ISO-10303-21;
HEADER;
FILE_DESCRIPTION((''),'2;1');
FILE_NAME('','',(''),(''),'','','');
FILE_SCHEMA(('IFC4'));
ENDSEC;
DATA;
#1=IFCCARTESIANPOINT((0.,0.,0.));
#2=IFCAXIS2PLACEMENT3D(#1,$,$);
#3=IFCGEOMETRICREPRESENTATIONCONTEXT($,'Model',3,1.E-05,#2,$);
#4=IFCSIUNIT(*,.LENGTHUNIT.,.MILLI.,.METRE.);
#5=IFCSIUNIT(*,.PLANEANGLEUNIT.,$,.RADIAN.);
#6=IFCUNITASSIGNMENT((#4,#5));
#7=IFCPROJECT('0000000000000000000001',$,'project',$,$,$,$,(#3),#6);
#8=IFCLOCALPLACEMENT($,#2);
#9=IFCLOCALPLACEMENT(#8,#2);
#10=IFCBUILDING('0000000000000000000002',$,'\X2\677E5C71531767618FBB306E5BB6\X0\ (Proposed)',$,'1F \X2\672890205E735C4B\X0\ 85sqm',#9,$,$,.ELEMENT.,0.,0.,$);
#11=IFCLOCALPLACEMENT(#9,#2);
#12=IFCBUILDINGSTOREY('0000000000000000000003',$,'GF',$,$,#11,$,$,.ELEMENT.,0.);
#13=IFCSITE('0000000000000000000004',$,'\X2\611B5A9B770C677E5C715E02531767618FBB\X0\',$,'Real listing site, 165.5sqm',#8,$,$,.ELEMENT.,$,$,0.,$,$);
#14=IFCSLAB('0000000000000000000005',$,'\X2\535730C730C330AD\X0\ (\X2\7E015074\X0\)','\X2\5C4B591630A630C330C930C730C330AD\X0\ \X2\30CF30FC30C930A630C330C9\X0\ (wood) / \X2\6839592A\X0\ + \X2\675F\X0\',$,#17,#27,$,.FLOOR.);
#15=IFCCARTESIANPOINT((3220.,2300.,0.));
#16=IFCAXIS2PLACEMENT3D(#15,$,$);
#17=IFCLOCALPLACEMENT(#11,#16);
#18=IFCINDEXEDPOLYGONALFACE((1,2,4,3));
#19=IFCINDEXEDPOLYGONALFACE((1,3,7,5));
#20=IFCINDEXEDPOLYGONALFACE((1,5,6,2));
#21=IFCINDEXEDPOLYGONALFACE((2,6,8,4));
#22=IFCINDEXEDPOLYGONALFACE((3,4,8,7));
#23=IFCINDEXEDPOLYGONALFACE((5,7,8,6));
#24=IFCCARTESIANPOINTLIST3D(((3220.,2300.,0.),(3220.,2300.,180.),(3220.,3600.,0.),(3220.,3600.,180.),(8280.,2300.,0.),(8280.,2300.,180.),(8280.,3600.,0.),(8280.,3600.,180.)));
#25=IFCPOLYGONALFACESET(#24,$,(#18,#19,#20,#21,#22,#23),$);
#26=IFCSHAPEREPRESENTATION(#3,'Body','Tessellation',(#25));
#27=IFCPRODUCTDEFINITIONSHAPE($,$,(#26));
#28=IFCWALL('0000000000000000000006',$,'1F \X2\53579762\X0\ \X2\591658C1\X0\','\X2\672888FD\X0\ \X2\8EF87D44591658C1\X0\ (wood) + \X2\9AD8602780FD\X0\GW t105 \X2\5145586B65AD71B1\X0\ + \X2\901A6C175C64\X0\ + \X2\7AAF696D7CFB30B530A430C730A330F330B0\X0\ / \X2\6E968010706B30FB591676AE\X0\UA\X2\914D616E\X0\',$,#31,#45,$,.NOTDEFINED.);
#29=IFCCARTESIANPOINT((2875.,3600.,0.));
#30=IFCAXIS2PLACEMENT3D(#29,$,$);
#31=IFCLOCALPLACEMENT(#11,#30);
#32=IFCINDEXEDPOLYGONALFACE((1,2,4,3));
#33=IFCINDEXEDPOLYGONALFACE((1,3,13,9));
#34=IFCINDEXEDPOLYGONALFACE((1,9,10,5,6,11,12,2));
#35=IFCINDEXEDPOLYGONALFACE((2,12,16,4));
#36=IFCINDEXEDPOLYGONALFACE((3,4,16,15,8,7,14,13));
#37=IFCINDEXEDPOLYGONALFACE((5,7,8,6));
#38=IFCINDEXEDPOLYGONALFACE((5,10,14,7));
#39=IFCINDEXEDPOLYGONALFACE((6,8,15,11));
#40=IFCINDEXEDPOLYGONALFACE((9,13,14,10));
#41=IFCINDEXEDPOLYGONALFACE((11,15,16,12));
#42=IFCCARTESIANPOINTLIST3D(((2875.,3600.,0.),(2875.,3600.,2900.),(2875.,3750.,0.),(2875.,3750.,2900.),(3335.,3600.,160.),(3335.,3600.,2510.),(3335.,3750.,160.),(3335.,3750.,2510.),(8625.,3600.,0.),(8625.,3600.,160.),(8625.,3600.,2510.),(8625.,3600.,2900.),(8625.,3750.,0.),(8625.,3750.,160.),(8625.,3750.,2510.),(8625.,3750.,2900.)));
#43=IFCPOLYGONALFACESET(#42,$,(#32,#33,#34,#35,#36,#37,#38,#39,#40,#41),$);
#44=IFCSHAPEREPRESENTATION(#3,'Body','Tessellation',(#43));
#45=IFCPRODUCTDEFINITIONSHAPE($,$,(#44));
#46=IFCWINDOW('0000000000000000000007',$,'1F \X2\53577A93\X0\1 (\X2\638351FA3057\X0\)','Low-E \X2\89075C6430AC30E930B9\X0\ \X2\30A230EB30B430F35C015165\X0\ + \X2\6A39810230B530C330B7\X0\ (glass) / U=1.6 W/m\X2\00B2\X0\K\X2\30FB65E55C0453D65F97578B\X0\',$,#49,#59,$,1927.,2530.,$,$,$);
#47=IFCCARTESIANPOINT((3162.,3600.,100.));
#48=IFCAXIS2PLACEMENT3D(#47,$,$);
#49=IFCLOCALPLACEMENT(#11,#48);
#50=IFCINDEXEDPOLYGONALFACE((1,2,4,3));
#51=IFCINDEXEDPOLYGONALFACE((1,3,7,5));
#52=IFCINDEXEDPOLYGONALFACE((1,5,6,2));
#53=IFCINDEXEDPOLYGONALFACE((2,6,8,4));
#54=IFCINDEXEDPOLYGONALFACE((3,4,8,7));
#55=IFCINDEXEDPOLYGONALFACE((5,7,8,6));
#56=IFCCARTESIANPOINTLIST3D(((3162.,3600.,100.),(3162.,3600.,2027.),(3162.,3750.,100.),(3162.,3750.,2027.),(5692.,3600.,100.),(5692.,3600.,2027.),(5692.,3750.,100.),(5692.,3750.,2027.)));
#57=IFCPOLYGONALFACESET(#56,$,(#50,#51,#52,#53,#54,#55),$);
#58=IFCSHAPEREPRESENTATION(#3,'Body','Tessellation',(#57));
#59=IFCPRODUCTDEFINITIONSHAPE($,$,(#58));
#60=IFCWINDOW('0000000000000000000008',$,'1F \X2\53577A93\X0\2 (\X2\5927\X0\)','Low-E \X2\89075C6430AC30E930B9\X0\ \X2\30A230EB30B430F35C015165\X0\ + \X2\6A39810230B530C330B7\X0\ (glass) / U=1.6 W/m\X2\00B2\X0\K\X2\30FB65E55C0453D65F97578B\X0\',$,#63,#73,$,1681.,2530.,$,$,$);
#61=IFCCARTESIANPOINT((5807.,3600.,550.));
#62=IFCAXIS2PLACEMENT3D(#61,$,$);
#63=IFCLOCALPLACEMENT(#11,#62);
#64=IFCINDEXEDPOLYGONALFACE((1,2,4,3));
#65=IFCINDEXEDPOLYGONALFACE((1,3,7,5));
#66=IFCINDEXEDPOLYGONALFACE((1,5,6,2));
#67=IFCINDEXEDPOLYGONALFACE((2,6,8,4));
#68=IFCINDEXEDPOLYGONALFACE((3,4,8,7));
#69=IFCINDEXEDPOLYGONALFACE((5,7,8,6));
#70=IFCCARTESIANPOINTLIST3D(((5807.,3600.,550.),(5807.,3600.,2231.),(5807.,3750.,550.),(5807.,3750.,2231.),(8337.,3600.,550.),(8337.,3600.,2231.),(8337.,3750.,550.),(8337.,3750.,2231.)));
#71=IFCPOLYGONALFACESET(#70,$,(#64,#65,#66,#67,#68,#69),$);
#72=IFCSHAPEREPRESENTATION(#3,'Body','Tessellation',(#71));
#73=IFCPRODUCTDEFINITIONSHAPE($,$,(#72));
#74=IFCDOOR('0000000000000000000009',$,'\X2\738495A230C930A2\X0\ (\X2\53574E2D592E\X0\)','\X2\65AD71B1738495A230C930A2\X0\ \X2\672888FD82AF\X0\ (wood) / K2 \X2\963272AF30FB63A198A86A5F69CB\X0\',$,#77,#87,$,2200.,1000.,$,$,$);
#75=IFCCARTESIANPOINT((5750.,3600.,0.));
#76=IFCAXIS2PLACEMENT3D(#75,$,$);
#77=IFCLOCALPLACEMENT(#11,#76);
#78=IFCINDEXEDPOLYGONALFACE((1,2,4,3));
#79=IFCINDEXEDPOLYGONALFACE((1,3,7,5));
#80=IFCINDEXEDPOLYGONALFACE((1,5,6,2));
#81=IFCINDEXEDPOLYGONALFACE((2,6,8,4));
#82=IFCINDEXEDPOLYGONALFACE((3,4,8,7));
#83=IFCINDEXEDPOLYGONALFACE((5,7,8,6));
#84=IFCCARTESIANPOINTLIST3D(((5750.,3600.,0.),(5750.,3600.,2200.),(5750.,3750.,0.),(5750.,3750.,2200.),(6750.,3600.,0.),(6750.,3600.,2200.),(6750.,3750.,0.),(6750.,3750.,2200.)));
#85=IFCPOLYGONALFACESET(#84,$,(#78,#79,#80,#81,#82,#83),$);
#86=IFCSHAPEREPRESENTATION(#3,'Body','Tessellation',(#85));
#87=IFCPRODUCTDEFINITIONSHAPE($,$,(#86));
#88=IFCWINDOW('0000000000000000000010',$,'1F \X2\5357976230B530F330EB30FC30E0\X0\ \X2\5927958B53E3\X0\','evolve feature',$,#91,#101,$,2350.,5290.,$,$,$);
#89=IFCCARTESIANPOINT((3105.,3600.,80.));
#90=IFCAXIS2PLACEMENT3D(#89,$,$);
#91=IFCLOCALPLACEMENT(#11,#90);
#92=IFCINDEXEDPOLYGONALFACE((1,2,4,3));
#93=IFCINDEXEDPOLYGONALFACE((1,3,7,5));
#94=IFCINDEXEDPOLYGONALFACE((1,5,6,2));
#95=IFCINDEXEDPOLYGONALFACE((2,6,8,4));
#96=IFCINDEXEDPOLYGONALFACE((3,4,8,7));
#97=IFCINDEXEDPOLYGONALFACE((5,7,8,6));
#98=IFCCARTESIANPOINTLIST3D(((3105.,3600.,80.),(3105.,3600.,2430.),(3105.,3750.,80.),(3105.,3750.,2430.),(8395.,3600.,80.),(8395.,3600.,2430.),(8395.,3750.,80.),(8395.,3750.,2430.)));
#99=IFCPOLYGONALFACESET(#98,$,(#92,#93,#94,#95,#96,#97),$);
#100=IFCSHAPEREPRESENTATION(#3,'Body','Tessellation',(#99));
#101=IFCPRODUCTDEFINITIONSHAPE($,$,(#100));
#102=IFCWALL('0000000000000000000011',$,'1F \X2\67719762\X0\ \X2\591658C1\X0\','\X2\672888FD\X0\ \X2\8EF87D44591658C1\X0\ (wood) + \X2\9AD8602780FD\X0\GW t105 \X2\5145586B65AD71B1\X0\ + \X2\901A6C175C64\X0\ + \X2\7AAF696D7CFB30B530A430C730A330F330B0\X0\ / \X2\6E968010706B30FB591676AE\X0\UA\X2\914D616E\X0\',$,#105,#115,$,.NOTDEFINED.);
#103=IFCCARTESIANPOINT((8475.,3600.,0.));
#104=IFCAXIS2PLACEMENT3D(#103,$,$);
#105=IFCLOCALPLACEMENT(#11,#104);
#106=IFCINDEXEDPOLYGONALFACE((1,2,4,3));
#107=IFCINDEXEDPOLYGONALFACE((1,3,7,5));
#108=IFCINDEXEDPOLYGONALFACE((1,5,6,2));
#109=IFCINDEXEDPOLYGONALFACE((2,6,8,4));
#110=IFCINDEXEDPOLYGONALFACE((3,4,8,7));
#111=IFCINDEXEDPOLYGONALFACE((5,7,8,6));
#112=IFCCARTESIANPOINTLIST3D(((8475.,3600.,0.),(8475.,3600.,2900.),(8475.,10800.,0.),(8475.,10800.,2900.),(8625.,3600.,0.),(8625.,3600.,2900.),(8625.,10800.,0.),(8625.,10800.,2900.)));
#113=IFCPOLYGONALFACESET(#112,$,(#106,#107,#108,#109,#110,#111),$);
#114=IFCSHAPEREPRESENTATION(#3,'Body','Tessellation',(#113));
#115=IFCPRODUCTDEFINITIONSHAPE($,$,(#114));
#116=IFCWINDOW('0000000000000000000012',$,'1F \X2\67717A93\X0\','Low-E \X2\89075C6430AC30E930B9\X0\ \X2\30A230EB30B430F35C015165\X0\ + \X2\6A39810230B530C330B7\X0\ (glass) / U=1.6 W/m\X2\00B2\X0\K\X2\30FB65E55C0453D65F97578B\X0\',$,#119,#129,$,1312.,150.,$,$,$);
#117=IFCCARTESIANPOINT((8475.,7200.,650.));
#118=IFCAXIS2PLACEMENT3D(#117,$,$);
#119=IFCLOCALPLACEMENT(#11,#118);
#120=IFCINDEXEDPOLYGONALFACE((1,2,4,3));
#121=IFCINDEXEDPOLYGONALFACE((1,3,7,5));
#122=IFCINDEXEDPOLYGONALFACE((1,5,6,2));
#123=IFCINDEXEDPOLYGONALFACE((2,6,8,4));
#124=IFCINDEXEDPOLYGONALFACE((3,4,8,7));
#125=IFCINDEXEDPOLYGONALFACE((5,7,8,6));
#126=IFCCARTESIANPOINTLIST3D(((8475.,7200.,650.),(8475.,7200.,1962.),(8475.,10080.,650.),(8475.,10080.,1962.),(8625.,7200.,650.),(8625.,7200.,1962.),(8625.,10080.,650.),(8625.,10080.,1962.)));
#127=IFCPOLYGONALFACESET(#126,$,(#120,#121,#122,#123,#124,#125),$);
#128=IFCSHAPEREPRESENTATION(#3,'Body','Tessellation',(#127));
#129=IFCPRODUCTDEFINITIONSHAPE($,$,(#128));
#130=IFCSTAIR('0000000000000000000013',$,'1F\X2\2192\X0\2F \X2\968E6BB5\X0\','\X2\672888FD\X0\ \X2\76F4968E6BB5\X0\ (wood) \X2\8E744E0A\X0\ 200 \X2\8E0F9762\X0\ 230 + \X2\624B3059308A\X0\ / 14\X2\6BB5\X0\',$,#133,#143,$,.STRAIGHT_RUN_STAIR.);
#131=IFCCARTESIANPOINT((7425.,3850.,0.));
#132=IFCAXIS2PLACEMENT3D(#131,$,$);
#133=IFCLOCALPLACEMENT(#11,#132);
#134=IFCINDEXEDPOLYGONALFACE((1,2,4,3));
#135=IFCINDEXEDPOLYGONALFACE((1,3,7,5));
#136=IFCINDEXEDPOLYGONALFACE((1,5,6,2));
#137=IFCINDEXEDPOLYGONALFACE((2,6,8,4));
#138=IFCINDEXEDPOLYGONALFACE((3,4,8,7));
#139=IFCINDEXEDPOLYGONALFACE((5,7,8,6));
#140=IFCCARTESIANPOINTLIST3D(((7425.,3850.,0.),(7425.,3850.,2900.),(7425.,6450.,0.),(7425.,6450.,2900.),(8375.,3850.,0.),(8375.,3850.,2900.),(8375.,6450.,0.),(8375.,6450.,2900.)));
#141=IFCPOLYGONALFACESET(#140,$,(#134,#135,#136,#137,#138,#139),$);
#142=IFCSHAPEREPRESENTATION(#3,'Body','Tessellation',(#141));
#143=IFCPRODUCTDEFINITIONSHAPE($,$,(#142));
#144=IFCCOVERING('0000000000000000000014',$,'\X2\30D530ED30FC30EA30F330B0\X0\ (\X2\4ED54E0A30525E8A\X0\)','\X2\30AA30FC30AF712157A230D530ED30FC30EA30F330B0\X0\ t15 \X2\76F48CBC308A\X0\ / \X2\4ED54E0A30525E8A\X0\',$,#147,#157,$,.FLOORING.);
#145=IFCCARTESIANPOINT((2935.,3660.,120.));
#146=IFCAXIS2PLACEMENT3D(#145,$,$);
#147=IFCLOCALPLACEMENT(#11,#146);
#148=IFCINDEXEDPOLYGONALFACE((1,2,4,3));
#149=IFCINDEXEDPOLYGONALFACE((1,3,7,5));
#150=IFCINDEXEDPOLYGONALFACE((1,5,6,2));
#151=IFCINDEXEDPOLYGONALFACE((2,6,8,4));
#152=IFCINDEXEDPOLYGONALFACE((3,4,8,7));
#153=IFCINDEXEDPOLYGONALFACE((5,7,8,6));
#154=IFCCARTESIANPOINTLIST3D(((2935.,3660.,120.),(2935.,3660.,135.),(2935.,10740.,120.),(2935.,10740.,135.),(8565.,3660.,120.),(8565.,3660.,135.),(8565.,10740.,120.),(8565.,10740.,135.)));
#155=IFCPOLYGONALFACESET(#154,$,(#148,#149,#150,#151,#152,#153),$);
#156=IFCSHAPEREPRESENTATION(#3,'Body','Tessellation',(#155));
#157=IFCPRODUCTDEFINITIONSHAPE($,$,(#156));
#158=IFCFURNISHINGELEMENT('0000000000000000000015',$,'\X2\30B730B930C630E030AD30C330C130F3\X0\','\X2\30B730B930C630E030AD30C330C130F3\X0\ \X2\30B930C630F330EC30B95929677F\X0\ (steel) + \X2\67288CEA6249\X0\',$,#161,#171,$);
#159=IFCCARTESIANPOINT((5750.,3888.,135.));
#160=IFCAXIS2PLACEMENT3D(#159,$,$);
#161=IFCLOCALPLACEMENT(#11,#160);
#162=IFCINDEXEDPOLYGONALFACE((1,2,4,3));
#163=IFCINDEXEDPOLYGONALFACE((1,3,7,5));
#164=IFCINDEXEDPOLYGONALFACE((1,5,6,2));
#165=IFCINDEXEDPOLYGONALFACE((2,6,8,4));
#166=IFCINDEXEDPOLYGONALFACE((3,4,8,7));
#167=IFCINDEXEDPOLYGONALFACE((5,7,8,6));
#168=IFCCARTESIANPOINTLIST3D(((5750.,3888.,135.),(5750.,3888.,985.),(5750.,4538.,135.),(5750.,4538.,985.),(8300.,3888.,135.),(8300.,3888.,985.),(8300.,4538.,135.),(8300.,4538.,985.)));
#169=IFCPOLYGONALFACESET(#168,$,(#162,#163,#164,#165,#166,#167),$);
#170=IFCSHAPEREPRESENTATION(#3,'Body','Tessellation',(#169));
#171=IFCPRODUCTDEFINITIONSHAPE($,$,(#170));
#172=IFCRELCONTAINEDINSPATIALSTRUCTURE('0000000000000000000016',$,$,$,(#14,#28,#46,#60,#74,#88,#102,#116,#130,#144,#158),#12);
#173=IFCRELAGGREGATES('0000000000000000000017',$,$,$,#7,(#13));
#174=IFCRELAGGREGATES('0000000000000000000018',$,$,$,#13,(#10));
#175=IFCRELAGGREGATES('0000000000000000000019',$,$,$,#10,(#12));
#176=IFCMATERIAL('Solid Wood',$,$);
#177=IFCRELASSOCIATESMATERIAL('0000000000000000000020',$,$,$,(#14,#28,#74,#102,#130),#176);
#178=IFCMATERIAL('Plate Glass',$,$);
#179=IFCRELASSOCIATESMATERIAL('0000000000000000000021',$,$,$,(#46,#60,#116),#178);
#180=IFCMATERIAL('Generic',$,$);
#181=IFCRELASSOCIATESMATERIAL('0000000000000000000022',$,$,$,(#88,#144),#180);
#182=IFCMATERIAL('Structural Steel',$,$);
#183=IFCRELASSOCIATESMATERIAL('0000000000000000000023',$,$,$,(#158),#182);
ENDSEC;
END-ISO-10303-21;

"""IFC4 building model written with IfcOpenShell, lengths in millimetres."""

from ifc_helpers import new_model, si_unit, frame, frame_2d, origin, place, context, project, spatial, rectangle, extrude, material, element, fill, save


model = new_model("IFC4")

# Units and contexts
model_context = context("Model", 3, precision=1e-05, world=origin())
ifc_project = project(units=[si_unit("LENGTHUNIT", "METRE", prefix="MILLI"), si_unit("PLANEANGLEUNIT", "RADIAN")], contexts=[model_context])

# Site, building, storey
site_placement = place(None, origin())
site = spatial("IfcSite", under=ifc_project, at=site_placement, Name="愛媛県松山市北条辻", ObjectType="Real listing site, 165.5sqm", CompositionType="ELEMENT", RefElevation=0.0)
building_placement = place(site_placement, origin())
building = spatial("IfcBuilding", under=site, at=building_placement, Name="松山北条辻の家 (Proposed)", ObjectType="1F 木造平屋 85sqm", CompositionType="ELEMENT", ElevationOfRefHeight=0.0, ElevationOfTerrain=0.0)
storey_placement = place(building_placement, origin())
storey = spatial("IfcBuildingStorey", under=building, at=storey_placement, Name="GF", CompositionType="ELEMENT", Elevation=0.0)

# Slab
ifc_material_1 = material(Name="Solid Wood")
slab_1_placement = place(storey_placement, frame((3220.0, 2300.0, 0.0)))
element("IfcSlab", 1, at=slab_1_placement, inside=storey, material=ifc_material_1, Name="南デッキ (縁側)", Description="屋外ウッドデッキ ハードウッド (wood) / 根太 + 束", PredefinedType="FLOOR", context=model_context, shape_type="SweptSolid", body=[
    extrude(rectangle(XDim=5060.0, YDim=1300.0, at=frame_2d((2530.0, 650.0))), frame((3220.0, 2300.0, 0.0)), (0.0, 0.0, 1.0), 180.0),
])
ifc_material_2 = material(Name="Generic")

# Wall, openings, windows, door
wall_1_placement = place(storey_placement, frame((2875.0, 3600.0, 0.0)))
wall_1 = element("IfcWall", 2, at=wall_1_placement, inside=storey, material=ifc_material_1, Name="1F 南面 外壁", Description="木製 軸組外壁 (wood) + 高性能GW t105 充填断熱 + 通気層 + 窯業系サイディング / 準耐火・外皮UA配慮", PredefinedType="NOTDEFINED", context=model_context, shape_type="SweptSolid", body=[
    extrude(rectangle(XDim=5750.0, YDim=150.0, at=frame_2d((2875.0, 75.0))), frame((2875.0, 3600.0, 0.0)), (0.0, 0.0, 1.0), 2900.0),
])
opening_1_placement = place(storey_placement, frame((3162.0, 3600.0, 100.0)))
opening_1 = element("IfcOpeningElement", 3, at=opening_1_placement, cuts=wall_1, PredefinedType="NOTDEFINED", context=model_context, shape_type="SweptSolid", body=[
    extrude(rectangle(XDim=2530.0, YDim=150.0, at=frame_2d((1265.0, 75.0))), frame((3162.0, 3600.0, 100.0)), (0.0, 0.0, 1.0), 1927.0),
])
opening_2_placement = place(storey_placement, frame((5807.0, 3600.0, 550.0)))
opening_2 = element("IfcOpeningElement", 4, at=opening_2_placement, cuts=wall_1, PredefinedType="NOTDEFINED", context=model_context, shape_type="SweptSolid", body=[
    extrude(rectangle(XDim=2530.0, YDim=150.0, at=frame_2d((1265.0, 75.0))), frame((5807.0, 3600.0, 550.0)), (0.0, 0.0, 1.0), 1681.0),
])
opening_3_placement = place(storey_placement, frame((5750.0, 3600.0, 0.0)))
opening_3 = element("IfcOpeningElement", 5, at=opening_3_placement, cuts=wall_1, PredefinedType="NOTDEFINED", context=model_context, shape_type="SweptSolid", body=[
    extrude(rectangle(XDim=1000.0, YDim=150.0, at=frame_2d((500.0, 75.0))), frame((5750.0, 3600.0, 0.0)), (0.0, 0.0, 1.0), 2200.0),
])
opening_4_placement = place(storey_placement, frame((3105.0, 3600.0, 80.0)))
opening_4 = element("IfcOpeningElement", 6, at=opening_4_placement, cuts=wall_1, PredefinedType="NOTDEFINED", context=model_context, shape_type="SweptSolid", body=[
    extrude(rectangle(XDim=5290.0, YDim=150.0, at=frame_2d((2645.0, 75.0))), frame((3105.0, 3600.0, 80.0)), (0.0, 0.0, 1.0), 2350.0),
])
ifc_material_3 = material(Name="Plate Glass")
window_1_placement = place(storey_placement, frame((3162.0, 3600.0, 100.0)))
window_1 = element("IfcWindow", 7, at=window_1_placement, inside=storey, material=ifc_material_3, Name="1F 南窓1 (掃出し)", Description="Low-E 複層ガラス アルゴン封入 + 樹脂サッシ (glass) / U=1.6 W/m²K・日射取得型", OverallHeight=1927.0, OverallWidth=2530.0, context=model_context, shape_type="SweptSolid", body=[
    extrude(rectangle(XDim=2530.0, YDim=150.0, at=frame_2d((1265.0, 75.0))), frame((3162.0, 3600.0, 100.0)), (0.0, 0.0, 1.0), 1927.0),
])
fill(opening_1, window_1)
window_2_placement = place(storey_placement, frame((5807.0, 3600.0, 550.0)))
window_2 = element("IfcWindow", 8, at=window_2_placement, inside=storey, material=ifc_material_3, Name="1F 南窓2 (大)", Description="Low-E 複層ガラス アルゴン封入 + 樹脂サッシ (glass) / U=1.6 W/m²K・日射取得型", OverallHeight=1681.0, OverallWidth=2530.0, context=model_context, shape_type="SweptSolid", body=[
    extrude(rectangle(XDim=2530.0, YDim=150.0, at=frame_2d((1265.0, 75.0))), frame((5807.0, 3600.0, 550.0)), (0.0, 0.0, 1.0), 1681.0),
])
fill(opening_2, window_2)
door_placement = place(storey_placement, frame((5750.0, 3600.0, 0.0)))
door = element("IfcDoor", 9, at=door_placement, inside=storey, material=ifc_material_1, Name="玄関ドア (南中央)", Description="断熱玄関ドア 木製芯 (wood) / K2 防犯・採風機構", OverallHeight=2200.0, OverallWidth=1000.0, context=model_context, shape_type="SweptSolid", body=[
    extrude(rectangle(XDim=1000.0, YDim=150.0, at=frame_2d((500.0, 75.0))), frame((5750.0, 3600.0, 0.0)), (0.0, 0.0, 1.0), 2200.0),
])
fill(opening_3, door)
window_3_placement = place(storey_placement, frame((3105.0, 3600.0, 80.0)))
window_3 = element("IfcWindow", 10, at=window_3_placement, inside=storey, material=ifc_material_2, Name="1F 南面サンルーム 大開口", Description="evolve feature", OverallHeight=2350.0, OverallWidth=5290.0, context=model_context, shape_type="SweptSolid", body=[
    extrude(rectangle(XDim=5290.0, YDim=150.0, at=frame_2d((2645.0, 75.0))), frame((3105.0, 3600.0, 80.0)), (0.0, 0.0, 1.0), 2350.0),
])
fill(opening_4, window_3)

# Wall, opening, window
wall_2_placement = place(storey_placement, frame((8475.0, 3600.0, 0.0)))
wall_2 = element("IfcWall", 11, at=wall_2_placement, inside=storey, material=ifc_material_1, Name="1F 東面 外壁", Description="木製 軸組外壁 (wood) + 高性能GW t105 充填断熱 + 通気層 + 窯業系サイディング / 準耐火・外皮UA配慮", PredefinedType="NOTDEFINED", context=model_context, shape_type="SweptSolid", body=[
    extrude(rectangle(XDim=150.0, YDim=7200.0, at=frame_2d((75.0, 3600.0))), frame((8475.0, 3600.0, 0.0)), (0.0, 0.0, 1.0), 2900.0),
])
opening_5_placement = place(storey_placement, frame((8475.0, 7200.0, 650.0)))
opening_5 = element("IfcOpeningElement", 12, at=opening_5_placement, cuts=wall_2, PredefinedType="NOTDEFINED", context=model_context, shape_type="SweptSolid", body=[
    extrude(rectangle(XDim=150.0, YDim=2880.0, at=frame_2d((75.0, 1440.0))), frame((8475.0, 7200.0, 650.0)), (0.0, 0.0, 1.0), 1312.0),
])
window_4_placement = place(storey_placement, frame((8475.0, 7200.0, 650.0)))
window_4 = element("IfcWindow", 13, at=window_4_placement, inside=storey, material=ifc_material_3, Name="1F 東窓", Description="Low-E 複層ガラス アルゴン封入 + 樹脂サッシ (glass) / U=1.6 W/m²K・日射取得型", OverallHeight=1312.0, OverallWidth=150.0, context=model_context, shape_type="SweptSolid", body=[
    extrude(rectangle(XDim=150.0, YDim=2880.0, at=frame_2d((75.0, 1440.0))), frame((8475.0, 7200.0, 650.0)), (0.0, 0.0, 1.0), 1312.0),
])
fill(opening_5, window_4)

# Stair
stair_placement = place(storey_placement, frame((7425.0, 3850.0, 0.0)))
element("IfcStair", 14, at=stair_placement, inside=storey, material=ifc_material_1, Name="1F→2F 階段", Description="木製 直階段 (wood) 蹴上 200 踏面 230 + 手すり / 14段", PredefinedType="STRAIGHT_RUN_STAIR", context=model_context, shape_type="SweptSolid", body=[
    extrude(rectangle(XDim=950.0, YDim=2600.0, at=frame_2d((475.0, 1300.0))), frame((7425.0, 3850.0, 0.0)), (0.0, 0.0, 1.0), 2900.0),
])

# Covering
covering_placement = place(storey_placement, frame((2935.0, 3660.0, 120.0)))
element("IfcCovering", 15, at=covering_placement, inside=storey, material=ifc_material_2, Name="フローリング (仕上げ床)", Description="オーク無垢フローリング t15 直貼り / 仕上げ床", PredefinedType="FLOORING", context=model_context, shape_type="SweptSolid", body=[
    extrude(rectangle(XDim=5630.0, YDim=7080.0, at=frame_2d((2815.0, 3540.0))), frame((2935.0, 3660.0, 120.0)), (0.0, 0.0, 1.0), 15.0),
])

# Furnishing element
ifc_material_4 = material(Name="Structural Steel")
furnishing_placement = place(storey_placement, frame((5750.0, 3888.0, 135.0)))
element("IfcFurnishingElement", 16, at=furnishing_placement, inside=storey, material=ifc_material_4, Name="システムキッチン", Description="システムキッチン ステンレス天板 (steel) + 木質扉", context=model_context, shape_type="SweptSolid", body=[
    extrude(rectangle(XDim=2550.0, YDim=650.0, at=frame_2d((1275.0, 325.0))), frame((5750.0, 3888.0, 135.0)), (0.0, 0.0, 1.0), 850.0),
])

save(model, "model.ifc")
